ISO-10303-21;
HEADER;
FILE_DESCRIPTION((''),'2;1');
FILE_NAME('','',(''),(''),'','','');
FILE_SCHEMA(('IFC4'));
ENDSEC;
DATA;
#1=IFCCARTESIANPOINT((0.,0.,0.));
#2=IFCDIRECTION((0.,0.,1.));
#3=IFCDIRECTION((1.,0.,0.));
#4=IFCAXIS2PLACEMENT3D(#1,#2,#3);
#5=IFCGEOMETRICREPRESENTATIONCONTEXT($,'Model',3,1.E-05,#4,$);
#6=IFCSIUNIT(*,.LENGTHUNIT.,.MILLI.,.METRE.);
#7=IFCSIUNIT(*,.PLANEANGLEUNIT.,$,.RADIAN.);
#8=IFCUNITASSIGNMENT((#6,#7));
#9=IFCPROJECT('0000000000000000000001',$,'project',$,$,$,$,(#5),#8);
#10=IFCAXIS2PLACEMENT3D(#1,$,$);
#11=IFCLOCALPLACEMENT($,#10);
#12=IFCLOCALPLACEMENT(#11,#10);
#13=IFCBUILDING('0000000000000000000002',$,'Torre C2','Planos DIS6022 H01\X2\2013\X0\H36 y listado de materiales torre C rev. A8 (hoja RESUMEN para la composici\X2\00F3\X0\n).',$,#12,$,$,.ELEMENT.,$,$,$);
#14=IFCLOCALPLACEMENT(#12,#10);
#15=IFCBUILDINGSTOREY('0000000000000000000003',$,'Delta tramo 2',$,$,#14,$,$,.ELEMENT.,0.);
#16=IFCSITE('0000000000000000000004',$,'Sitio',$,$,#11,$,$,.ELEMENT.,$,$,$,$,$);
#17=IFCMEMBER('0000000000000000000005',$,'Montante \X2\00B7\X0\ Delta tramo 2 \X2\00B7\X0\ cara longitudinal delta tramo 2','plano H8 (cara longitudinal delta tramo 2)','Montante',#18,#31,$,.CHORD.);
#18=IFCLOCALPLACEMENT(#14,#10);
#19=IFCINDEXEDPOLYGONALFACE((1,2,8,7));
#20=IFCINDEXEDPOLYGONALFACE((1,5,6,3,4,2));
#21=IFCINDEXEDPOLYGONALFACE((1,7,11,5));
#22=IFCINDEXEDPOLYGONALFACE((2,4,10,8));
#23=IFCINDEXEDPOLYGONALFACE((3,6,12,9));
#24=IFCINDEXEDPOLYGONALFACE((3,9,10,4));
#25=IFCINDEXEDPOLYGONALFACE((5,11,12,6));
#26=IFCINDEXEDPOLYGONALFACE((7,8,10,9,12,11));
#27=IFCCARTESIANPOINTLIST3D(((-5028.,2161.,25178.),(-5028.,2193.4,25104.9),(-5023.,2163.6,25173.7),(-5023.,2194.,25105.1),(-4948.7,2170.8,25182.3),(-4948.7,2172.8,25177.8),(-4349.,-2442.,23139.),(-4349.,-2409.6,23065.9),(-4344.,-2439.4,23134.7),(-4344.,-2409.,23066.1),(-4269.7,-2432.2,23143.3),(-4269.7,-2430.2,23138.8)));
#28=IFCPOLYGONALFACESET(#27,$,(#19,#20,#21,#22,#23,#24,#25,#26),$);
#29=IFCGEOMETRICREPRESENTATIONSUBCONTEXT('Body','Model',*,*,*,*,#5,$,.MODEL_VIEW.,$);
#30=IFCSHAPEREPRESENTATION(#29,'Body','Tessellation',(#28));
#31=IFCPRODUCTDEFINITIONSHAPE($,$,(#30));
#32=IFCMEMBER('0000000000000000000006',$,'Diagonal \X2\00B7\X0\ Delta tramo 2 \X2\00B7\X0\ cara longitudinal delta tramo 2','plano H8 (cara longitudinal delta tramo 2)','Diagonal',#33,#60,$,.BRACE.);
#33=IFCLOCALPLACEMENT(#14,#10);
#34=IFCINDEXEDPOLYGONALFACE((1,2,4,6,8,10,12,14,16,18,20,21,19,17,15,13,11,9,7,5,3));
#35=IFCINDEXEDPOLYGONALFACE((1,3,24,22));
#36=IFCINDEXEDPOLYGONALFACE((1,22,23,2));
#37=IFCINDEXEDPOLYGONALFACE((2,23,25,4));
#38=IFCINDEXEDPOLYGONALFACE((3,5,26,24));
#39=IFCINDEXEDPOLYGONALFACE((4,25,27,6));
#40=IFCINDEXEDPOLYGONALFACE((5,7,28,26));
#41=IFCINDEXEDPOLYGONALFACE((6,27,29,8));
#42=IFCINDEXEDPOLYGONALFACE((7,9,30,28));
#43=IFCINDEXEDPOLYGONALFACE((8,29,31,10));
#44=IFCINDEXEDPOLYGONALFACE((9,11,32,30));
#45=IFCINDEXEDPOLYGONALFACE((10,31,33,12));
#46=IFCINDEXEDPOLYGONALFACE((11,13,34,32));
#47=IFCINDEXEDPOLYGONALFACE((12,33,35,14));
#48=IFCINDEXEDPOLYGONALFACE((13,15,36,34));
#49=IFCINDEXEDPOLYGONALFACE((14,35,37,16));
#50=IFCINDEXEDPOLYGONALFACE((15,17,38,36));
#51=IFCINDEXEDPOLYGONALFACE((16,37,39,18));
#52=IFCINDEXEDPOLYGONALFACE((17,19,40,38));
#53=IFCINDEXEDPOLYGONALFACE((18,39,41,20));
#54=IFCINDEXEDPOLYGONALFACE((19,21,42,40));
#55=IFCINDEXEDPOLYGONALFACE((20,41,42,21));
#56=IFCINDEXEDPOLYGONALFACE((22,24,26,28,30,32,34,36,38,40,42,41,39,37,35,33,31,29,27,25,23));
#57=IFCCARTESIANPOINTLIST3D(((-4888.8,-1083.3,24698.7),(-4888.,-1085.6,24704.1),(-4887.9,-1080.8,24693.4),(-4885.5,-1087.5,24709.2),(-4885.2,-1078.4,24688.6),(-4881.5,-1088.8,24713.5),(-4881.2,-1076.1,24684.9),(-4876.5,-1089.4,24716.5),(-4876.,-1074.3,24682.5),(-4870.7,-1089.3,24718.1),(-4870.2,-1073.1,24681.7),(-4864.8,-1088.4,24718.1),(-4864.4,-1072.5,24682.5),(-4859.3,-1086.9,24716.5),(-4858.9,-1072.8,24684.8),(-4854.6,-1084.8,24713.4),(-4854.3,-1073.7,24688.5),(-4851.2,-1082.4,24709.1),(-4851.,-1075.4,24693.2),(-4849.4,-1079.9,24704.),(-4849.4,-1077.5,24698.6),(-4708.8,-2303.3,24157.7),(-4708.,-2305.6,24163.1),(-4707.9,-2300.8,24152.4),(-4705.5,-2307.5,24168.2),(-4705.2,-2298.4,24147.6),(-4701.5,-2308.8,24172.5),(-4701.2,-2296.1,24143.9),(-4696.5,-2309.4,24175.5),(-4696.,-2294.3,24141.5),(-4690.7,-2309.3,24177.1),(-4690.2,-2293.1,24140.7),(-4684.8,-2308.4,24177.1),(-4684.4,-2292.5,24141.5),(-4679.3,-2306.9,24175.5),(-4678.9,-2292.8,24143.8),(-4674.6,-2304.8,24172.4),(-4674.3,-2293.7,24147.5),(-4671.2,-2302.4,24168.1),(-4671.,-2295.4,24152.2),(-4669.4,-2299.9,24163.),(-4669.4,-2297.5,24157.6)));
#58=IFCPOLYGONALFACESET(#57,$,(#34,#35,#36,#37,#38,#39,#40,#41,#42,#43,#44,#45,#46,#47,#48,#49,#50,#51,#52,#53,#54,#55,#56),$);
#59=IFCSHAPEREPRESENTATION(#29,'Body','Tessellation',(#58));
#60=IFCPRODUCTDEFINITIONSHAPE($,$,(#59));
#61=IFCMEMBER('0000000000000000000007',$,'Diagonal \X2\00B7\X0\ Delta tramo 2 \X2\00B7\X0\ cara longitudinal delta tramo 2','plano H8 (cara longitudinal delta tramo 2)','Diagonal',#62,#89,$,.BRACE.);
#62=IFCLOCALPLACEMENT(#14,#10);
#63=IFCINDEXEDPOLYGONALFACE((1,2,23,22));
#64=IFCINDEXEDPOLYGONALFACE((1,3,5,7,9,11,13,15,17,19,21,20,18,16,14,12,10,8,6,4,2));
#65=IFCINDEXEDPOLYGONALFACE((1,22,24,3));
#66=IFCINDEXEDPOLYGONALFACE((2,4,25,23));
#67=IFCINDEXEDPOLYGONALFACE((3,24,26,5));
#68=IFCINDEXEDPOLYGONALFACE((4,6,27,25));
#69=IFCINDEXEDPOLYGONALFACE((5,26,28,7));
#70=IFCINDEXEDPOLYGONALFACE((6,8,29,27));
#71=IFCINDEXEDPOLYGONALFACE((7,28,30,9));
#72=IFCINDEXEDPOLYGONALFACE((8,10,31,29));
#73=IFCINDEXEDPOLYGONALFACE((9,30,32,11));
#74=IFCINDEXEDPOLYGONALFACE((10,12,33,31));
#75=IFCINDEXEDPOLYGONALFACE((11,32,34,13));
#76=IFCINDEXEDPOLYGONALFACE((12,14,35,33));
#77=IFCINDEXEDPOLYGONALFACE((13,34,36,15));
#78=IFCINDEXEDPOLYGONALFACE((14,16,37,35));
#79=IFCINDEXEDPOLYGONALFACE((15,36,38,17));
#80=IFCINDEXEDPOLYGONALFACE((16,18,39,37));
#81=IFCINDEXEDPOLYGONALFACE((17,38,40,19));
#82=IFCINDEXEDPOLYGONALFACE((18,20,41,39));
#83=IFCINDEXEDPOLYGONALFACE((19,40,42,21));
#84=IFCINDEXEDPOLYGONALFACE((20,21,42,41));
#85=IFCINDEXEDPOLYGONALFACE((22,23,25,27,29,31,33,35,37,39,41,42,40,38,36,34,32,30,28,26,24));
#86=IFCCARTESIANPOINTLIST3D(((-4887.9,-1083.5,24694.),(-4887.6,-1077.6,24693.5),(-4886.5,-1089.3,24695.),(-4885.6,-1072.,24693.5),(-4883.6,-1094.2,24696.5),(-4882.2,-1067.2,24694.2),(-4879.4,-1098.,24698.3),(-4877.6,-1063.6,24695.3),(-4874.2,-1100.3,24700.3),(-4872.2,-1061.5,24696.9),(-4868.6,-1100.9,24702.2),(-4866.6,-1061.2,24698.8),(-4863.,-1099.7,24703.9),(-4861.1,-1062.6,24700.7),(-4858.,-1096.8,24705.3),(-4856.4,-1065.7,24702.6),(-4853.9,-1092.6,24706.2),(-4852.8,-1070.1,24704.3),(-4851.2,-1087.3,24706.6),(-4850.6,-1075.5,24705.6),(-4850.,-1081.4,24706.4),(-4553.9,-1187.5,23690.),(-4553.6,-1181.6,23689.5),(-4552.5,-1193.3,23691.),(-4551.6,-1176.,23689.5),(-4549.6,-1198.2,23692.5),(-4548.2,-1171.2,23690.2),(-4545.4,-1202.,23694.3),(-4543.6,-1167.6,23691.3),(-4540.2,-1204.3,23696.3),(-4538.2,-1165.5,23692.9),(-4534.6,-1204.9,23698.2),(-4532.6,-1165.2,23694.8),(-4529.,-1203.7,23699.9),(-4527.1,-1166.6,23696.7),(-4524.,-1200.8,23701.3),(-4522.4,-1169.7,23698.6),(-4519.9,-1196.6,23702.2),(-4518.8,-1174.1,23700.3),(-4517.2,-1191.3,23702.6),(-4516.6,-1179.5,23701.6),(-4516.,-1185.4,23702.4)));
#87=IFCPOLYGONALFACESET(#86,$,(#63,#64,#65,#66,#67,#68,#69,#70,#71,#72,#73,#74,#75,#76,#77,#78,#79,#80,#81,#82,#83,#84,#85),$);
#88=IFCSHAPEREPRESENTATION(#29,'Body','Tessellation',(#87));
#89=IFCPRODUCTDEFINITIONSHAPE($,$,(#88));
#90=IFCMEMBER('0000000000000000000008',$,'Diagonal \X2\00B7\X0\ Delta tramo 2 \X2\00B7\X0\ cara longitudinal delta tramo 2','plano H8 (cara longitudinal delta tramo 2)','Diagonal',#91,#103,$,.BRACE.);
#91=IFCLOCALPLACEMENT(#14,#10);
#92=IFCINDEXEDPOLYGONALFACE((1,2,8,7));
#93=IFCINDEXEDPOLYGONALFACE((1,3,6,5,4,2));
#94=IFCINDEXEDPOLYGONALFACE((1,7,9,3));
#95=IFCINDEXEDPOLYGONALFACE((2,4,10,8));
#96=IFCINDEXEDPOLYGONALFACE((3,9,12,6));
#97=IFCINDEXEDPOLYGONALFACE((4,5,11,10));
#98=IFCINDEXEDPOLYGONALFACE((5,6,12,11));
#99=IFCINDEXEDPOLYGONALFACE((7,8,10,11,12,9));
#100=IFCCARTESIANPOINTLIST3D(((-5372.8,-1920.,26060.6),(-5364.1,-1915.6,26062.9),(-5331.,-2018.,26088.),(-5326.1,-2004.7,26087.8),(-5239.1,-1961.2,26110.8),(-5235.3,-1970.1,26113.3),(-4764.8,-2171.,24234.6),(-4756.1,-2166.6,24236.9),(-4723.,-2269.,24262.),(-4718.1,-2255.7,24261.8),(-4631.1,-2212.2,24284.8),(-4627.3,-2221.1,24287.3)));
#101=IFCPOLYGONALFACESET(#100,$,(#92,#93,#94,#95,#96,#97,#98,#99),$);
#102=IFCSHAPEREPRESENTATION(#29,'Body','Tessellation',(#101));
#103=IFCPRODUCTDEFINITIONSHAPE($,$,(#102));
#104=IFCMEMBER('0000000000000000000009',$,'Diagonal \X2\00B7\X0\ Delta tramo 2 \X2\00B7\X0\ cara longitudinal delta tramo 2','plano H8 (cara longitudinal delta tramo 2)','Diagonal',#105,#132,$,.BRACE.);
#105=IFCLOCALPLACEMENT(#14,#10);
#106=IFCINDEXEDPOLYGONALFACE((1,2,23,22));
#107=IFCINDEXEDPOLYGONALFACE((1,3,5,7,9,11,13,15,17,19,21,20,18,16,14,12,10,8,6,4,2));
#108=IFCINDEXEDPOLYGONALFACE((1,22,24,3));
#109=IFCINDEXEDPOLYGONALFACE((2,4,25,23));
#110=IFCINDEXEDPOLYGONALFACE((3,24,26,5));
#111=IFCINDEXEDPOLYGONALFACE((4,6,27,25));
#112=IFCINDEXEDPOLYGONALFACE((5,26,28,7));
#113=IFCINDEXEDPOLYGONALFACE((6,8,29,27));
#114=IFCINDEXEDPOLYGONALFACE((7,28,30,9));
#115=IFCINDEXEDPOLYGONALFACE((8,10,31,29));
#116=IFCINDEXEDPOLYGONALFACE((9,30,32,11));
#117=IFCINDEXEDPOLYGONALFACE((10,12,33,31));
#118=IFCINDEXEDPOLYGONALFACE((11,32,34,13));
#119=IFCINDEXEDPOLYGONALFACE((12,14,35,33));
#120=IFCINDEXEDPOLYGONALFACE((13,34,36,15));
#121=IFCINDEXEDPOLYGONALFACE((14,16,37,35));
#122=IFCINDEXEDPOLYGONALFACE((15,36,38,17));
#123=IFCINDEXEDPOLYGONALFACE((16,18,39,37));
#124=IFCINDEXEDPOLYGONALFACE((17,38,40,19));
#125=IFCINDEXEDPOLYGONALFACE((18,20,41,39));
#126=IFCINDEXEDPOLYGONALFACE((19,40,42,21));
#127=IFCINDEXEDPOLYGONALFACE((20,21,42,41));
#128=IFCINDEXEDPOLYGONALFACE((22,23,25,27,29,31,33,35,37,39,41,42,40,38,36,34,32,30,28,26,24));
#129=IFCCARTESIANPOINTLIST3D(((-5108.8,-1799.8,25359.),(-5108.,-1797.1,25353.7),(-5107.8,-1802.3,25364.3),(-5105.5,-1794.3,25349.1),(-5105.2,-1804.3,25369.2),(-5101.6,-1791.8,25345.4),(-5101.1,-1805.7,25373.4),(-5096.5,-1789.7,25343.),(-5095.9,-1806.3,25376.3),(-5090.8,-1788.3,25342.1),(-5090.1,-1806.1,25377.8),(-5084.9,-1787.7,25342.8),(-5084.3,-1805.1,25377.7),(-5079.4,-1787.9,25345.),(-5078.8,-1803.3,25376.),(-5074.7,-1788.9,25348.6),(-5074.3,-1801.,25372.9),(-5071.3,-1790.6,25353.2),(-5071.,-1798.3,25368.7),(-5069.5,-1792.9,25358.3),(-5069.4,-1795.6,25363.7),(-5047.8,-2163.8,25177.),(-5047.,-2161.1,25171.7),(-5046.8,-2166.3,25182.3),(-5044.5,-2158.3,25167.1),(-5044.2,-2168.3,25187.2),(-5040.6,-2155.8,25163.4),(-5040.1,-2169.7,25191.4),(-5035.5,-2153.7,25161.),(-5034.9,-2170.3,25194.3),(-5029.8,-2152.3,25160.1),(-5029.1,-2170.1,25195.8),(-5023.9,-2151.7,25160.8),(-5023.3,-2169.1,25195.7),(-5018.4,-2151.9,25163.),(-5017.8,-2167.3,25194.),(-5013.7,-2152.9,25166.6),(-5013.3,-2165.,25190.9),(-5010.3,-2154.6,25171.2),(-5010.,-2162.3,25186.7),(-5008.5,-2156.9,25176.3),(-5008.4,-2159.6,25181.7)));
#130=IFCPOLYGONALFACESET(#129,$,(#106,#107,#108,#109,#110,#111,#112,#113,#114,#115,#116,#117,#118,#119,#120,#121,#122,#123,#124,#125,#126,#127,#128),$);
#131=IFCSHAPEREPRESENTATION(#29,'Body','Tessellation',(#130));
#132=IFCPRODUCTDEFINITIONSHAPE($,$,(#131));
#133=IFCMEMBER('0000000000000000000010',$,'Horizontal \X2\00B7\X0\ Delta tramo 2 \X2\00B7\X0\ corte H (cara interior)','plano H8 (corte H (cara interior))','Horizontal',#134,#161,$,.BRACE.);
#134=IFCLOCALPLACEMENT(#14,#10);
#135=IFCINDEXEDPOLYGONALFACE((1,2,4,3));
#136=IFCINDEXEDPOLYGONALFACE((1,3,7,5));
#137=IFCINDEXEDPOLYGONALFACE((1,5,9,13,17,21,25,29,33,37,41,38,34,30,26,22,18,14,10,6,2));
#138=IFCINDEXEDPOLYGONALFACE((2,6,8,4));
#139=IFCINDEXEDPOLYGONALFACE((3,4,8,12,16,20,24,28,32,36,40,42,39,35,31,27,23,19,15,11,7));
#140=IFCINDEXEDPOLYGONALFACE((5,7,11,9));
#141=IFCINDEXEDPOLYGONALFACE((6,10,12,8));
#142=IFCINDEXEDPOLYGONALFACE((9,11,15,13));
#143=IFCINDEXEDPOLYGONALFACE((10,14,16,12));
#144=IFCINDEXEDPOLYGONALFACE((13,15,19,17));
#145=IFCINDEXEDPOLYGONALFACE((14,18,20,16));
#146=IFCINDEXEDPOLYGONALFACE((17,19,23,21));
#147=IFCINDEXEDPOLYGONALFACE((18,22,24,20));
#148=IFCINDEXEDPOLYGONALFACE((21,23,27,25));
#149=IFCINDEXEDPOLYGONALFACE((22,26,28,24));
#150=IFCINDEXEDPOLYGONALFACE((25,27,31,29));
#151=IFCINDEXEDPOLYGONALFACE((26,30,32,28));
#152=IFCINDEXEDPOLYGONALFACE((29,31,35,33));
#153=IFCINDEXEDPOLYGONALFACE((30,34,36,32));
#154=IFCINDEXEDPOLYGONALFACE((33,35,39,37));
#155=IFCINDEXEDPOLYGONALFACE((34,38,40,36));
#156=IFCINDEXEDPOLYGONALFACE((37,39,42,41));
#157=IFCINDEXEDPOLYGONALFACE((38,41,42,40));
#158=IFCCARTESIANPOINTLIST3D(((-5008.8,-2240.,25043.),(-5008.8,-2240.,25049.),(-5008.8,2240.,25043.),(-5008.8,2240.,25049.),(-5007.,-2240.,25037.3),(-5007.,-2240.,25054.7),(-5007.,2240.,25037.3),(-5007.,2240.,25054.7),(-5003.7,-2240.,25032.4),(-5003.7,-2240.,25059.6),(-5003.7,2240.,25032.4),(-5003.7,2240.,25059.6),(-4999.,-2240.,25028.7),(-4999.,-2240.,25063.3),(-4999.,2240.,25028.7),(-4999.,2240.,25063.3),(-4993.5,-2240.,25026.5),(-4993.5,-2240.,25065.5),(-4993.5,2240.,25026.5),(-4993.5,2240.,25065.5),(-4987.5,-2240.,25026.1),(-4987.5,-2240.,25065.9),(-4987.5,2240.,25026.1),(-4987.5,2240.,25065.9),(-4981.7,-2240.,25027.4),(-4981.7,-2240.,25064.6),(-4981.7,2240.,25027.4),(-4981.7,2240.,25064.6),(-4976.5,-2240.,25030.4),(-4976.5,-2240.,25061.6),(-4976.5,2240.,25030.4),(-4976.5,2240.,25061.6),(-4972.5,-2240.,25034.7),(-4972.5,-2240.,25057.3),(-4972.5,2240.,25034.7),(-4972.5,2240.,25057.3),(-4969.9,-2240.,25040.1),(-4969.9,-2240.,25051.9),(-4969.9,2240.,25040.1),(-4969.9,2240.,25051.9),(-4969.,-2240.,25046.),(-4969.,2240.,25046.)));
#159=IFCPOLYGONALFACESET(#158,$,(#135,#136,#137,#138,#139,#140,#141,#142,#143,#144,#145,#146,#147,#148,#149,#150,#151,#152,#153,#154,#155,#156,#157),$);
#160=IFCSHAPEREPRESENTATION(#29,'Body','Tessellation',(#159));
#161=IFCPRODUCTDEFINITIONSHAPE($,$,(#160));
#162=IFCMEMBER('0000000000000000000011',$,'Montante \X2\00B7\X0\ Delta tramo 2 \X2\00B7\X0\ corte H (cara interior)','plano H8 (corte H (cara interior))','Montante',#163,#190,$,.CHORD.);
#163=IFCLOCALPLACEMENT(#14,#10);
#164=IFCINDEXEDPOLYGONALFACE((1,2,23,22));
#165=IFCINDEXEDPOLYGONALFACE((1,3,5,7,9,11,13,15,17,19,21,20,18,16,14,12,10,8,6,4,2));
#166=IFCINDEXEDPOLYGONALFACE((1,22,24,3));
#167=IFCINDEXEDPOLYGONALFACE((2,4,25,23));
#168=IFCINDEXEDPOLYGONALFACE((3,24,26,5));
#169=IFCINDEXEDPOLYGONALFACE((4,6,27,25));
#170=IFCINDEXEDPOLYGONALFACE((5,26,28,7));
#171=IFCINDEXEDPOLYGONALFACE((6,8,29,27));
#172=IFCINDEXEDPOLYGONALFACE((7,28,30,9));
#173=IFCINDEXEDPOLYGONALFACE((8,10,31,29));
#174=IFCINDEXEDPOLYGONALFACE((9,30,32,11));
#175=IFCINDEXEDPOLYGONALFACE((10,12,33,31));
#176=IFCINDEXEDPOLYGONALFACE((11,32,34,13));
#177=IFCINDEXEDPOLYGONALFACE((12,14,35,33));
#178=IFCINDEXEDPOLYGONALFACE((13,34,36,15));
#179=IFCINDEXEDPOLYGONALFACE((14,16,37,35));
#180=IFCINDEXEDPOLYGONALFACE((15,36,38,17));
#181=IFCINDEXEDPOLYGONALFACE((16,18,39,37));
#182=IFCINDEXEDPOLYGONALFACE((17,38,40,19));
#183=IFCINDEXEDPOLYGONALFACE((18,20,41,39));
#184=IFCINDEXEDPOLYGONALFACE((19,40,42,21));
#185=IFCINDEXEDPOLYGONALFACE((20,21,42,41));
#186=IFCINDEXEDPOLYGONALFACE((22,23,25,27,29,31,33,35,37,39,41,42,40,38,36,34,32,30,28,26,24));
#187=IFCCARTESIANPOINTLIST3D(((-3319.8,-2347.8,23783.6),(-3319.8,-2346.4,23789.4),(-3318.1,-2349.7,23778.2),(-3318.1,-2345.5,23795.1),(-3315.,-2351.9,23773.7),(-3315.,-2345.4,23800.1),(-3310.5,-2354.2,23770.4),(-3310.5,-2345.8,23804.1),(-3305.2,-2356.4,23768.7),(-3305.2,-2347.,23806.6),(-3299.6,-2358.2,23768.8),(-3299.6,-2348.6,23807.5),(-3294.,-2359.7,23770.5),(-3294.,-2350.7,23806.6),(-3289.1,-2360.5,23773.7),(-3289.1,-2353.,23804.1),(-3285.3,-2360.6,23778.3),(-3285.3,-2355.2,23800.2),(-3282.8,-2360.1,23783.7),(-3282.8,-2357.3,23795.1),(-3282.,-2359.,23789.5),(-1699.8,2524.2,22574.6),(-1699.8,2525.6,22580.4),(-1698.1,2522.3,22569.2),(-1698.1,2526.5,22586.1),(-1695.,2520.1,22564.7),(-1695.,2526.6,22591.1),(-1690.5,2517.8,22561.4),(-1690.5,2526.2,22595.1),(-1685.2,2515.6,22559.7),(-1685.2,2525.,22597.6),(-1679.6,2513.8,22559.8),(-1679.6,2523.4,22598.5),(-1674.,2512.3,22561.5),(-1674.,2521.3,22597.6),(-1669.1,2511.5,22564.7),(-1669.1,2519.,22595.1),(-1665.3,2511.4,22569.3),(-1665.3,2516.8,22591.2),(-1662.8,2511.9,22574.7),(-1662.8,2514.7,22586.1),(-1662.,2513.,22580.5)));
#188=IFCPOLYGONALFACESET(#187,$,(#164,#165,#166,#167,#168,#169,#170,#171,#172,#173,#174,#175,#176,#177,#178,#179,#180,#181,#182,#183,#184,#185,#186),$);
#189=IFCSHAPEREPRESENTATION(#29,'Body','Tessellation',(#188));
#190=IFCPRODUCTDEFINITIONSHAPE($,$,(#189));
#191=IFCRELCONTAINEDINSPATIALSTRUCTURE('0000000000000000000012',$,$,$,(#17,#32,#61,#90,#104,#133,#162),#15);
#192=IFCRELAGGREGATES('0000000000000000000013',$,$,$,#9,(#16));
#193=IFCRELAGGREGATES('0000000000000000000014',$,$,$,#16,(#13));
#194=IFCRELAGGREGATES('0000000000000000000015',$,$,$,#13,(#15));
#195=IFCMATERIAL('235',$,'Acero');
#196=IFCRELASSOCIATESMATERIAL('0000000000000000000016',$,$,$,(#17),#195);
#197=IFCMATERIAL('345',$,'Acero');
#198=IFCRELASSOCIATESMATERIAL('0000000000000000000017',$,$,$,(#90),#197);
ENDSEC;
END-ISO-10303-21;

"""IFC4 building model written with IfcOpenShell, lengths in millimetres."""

from ifc_helpers import new_model, si_unit, frame, frame_2d, origin, origin_with_axes, place, context, subcontext, project, spatial, circle, l_section, extrude, material, element, save


model = new_model("IFC4")

# Units and contexts
model_context = context("Model", 3, precision=1e-05, world=origin_with_axes())
body_context = subcontext(model_context, "Body", "Model", "MODEL_VIEW")
ifc_project = project(units=[si_unit("LENGTHUNIT", "METRE", prefix="MILLI"), si_unit("PLANEANGLEUNIT", "RADIAN")], contexts=[model_context])

# Site, building, storey
site_placement = place(None, origin())
site = spatial("IfcSite", under=ifc_project, at=site_placement, Name="Sitio", CompositionType="ELEMENT")
building_placement = place(site_placement, origin())
building = spatial("IfcBuilding", under=site, at=building_placement, Name="Torre C2", Description="Planos DIS6022 H01–H36 y listado de materiales torre C rev. A8 (hoja RESUMEN para la composición).", CompositionType="ELEMENT")
storey_placement = place(building_placement, origin())
storey = spatial("IfcBuildingStorey", under=building, at=storey_placement, Name="Delta tramo 2", CompositionType="ELEMENT", Elevation=0.0)

# Members
ifc_material_1 = material(Name="345", Category="Acero")
ifc_material_2 = material(Name="235", Category="Acero")
member_1_placement = place(storey_placement, frame((-4349.0, -2442.0, 23139.0), z_axis=(-0.133662, 0.906106, 0.40138), x_axis=(0.991027, 0.122209, 0.054135)))
element("IfcMember", 1, at=member_1_placement, inside=storey, material=ifc_material_2, Name="Montante · Delta tramo 2 · cara longitudinal delta tramo 2", Description="plano H8 (cara longitudinal delta tramo 2)", ObjectType="Montante", PredefinedType="CHORD", context=body_context, shape_type="SweptSolid", body=[
    extrude(l_section(Depth=80.0, Width=80.0, Thickness=5.0, at=frame_2d((40.0, 40.0))), None, (0.0, 0.0, 1.0), 5080.0),
])
member_2_placement = place(storey_placement, frame((-4689.0, -2301.0, 24159.0), z_axis=(-0.133664, 0.905948, 0.401736), x_axis=(0.981631, 0.176718, -0.071907)))
element("IfcMember", 2, at=member_2_placement, inside=storey, Name="Diagonal · Delta tramo 2 · cara longitudinal delta tramo 2", Description="plano H8 (cara longitudinal delta tramo 2)", ObjectType="Diagonal", PredefinedType="BRACE", context=body_context, shape_type="SweptSolid", body=[
    extrude(circle(Radius=20.0), None, (0.0, 0.0, 1.0), 1346.7),
])
member_3_placement = place(storey_placement, frame((-4869.0, -1081.0, 24700.0), z_axis=(0.314147, -0.097818, -0.944322), x_axis=(0.920941, 0.273009, 0.278089)))
element("IfcMember", 3, at=member_3_placement, inside=storey, Name="Diagonal · Delta tramo 2 · cara longitudinal delta tramo 2", Description="plano H8 (cara longitudinal delta tramo 2)", ObjectType="Diagonal", PredefinedType="BRACE", context=body_context, shape_type="SweptSolid", body=[
    extrude(circle(Radius=20.0), None, (0.0, 0.0, 1.0), 1063.2),
])
member_4_placement = place(storey_placement, frame((-4723.0, -2269.0, 24262.0), z_axis=(-0.313263, 0.129324, 0.94082), x_axis=(0.870378, 0.435386, 0.22996)))
element("IfcMember", 4, at=member_4_placement, inside=storey, material=ifc_material_1, Name="Diagonal · Delta tramo 2 · cara longitudinal delta tramo 2", Description="plano H8 (cara longitudinal delta tramo 2)", ObjectType="Diagonal", PredefinedType="BRACE", context=body_context, shape_type="SweptSolid", body=[
    extrude(l_section(Depth=110.0, Width=110.0, Thickness=10.0, at=frame_2d((55.0, 55.0))), None, (0.0, 0.0, 1.0), 1940.9),
])
member_5_placement = place(storey_placement, frame((-5028.0, -2161.0, 25178.0), z_axis=(-0.148234, 0.884546, 0.442273), x_axis=(0.975269, 0.204886, -0.082896)))
element("IfcMember", 5, at=member_5_placement, inside=storey, Name="Diagonal · Delta tramo 2 · cara longitudinal delta tramo 2", Description="plano H8 (cara longitudinal delta tramo 2)", ObjectType="Diagonal", PredefinedType="BRACE", context=body_context, shape_type="SweptSolid", body=[
    extrude(circle(Radius=20.0), None, (0.0, 0.0, 1.0), 411.5),
])
member_6_placement = place(storey_placement, frame((-4989.0, -2240.0, 25046.0), z_axis=(0.0, 1.0, 0.0), x_axis=(1.0, 0.0, 0.0)))
element("IfcMember", 6, at=member_6_placement, inside=storey, Name="Horizontal · Delta tramo 2 · corte H (cara interior)", Description="plano H8 (corte H (cara interior))", ObjectType="Horizontal", PredefinedType="BRACE", context=body_context, shape_type="SweptSolid", body=[
    extrude(circle(Radius=20.0), None, (0.0, 0.0, 1.0), 4480.0),
])
member_7_placement = place(storey_placement, frame((-3301.0, -2353.0, 23788.0), z_axis=(0.307126, 0.923654, -0.229207), x_axis=(0.951669, -0.298086, 0.073971)))
element("IfcMember", 7, at=member_7_placement, inside=storey, Name="Montante · Delta tramo 2 · corte H (cara interior)", Description="plano H8 (corte H (cara interior))", ObjectType="Montante", PredefinedType="CHORD", context=body_context, shape_type="SweptSolid", body=[
    extrude(circle(Radius=20.0), None, (0.0, 0.0, 1.0), 5274.7),
])

save(model, "model.ifc")
